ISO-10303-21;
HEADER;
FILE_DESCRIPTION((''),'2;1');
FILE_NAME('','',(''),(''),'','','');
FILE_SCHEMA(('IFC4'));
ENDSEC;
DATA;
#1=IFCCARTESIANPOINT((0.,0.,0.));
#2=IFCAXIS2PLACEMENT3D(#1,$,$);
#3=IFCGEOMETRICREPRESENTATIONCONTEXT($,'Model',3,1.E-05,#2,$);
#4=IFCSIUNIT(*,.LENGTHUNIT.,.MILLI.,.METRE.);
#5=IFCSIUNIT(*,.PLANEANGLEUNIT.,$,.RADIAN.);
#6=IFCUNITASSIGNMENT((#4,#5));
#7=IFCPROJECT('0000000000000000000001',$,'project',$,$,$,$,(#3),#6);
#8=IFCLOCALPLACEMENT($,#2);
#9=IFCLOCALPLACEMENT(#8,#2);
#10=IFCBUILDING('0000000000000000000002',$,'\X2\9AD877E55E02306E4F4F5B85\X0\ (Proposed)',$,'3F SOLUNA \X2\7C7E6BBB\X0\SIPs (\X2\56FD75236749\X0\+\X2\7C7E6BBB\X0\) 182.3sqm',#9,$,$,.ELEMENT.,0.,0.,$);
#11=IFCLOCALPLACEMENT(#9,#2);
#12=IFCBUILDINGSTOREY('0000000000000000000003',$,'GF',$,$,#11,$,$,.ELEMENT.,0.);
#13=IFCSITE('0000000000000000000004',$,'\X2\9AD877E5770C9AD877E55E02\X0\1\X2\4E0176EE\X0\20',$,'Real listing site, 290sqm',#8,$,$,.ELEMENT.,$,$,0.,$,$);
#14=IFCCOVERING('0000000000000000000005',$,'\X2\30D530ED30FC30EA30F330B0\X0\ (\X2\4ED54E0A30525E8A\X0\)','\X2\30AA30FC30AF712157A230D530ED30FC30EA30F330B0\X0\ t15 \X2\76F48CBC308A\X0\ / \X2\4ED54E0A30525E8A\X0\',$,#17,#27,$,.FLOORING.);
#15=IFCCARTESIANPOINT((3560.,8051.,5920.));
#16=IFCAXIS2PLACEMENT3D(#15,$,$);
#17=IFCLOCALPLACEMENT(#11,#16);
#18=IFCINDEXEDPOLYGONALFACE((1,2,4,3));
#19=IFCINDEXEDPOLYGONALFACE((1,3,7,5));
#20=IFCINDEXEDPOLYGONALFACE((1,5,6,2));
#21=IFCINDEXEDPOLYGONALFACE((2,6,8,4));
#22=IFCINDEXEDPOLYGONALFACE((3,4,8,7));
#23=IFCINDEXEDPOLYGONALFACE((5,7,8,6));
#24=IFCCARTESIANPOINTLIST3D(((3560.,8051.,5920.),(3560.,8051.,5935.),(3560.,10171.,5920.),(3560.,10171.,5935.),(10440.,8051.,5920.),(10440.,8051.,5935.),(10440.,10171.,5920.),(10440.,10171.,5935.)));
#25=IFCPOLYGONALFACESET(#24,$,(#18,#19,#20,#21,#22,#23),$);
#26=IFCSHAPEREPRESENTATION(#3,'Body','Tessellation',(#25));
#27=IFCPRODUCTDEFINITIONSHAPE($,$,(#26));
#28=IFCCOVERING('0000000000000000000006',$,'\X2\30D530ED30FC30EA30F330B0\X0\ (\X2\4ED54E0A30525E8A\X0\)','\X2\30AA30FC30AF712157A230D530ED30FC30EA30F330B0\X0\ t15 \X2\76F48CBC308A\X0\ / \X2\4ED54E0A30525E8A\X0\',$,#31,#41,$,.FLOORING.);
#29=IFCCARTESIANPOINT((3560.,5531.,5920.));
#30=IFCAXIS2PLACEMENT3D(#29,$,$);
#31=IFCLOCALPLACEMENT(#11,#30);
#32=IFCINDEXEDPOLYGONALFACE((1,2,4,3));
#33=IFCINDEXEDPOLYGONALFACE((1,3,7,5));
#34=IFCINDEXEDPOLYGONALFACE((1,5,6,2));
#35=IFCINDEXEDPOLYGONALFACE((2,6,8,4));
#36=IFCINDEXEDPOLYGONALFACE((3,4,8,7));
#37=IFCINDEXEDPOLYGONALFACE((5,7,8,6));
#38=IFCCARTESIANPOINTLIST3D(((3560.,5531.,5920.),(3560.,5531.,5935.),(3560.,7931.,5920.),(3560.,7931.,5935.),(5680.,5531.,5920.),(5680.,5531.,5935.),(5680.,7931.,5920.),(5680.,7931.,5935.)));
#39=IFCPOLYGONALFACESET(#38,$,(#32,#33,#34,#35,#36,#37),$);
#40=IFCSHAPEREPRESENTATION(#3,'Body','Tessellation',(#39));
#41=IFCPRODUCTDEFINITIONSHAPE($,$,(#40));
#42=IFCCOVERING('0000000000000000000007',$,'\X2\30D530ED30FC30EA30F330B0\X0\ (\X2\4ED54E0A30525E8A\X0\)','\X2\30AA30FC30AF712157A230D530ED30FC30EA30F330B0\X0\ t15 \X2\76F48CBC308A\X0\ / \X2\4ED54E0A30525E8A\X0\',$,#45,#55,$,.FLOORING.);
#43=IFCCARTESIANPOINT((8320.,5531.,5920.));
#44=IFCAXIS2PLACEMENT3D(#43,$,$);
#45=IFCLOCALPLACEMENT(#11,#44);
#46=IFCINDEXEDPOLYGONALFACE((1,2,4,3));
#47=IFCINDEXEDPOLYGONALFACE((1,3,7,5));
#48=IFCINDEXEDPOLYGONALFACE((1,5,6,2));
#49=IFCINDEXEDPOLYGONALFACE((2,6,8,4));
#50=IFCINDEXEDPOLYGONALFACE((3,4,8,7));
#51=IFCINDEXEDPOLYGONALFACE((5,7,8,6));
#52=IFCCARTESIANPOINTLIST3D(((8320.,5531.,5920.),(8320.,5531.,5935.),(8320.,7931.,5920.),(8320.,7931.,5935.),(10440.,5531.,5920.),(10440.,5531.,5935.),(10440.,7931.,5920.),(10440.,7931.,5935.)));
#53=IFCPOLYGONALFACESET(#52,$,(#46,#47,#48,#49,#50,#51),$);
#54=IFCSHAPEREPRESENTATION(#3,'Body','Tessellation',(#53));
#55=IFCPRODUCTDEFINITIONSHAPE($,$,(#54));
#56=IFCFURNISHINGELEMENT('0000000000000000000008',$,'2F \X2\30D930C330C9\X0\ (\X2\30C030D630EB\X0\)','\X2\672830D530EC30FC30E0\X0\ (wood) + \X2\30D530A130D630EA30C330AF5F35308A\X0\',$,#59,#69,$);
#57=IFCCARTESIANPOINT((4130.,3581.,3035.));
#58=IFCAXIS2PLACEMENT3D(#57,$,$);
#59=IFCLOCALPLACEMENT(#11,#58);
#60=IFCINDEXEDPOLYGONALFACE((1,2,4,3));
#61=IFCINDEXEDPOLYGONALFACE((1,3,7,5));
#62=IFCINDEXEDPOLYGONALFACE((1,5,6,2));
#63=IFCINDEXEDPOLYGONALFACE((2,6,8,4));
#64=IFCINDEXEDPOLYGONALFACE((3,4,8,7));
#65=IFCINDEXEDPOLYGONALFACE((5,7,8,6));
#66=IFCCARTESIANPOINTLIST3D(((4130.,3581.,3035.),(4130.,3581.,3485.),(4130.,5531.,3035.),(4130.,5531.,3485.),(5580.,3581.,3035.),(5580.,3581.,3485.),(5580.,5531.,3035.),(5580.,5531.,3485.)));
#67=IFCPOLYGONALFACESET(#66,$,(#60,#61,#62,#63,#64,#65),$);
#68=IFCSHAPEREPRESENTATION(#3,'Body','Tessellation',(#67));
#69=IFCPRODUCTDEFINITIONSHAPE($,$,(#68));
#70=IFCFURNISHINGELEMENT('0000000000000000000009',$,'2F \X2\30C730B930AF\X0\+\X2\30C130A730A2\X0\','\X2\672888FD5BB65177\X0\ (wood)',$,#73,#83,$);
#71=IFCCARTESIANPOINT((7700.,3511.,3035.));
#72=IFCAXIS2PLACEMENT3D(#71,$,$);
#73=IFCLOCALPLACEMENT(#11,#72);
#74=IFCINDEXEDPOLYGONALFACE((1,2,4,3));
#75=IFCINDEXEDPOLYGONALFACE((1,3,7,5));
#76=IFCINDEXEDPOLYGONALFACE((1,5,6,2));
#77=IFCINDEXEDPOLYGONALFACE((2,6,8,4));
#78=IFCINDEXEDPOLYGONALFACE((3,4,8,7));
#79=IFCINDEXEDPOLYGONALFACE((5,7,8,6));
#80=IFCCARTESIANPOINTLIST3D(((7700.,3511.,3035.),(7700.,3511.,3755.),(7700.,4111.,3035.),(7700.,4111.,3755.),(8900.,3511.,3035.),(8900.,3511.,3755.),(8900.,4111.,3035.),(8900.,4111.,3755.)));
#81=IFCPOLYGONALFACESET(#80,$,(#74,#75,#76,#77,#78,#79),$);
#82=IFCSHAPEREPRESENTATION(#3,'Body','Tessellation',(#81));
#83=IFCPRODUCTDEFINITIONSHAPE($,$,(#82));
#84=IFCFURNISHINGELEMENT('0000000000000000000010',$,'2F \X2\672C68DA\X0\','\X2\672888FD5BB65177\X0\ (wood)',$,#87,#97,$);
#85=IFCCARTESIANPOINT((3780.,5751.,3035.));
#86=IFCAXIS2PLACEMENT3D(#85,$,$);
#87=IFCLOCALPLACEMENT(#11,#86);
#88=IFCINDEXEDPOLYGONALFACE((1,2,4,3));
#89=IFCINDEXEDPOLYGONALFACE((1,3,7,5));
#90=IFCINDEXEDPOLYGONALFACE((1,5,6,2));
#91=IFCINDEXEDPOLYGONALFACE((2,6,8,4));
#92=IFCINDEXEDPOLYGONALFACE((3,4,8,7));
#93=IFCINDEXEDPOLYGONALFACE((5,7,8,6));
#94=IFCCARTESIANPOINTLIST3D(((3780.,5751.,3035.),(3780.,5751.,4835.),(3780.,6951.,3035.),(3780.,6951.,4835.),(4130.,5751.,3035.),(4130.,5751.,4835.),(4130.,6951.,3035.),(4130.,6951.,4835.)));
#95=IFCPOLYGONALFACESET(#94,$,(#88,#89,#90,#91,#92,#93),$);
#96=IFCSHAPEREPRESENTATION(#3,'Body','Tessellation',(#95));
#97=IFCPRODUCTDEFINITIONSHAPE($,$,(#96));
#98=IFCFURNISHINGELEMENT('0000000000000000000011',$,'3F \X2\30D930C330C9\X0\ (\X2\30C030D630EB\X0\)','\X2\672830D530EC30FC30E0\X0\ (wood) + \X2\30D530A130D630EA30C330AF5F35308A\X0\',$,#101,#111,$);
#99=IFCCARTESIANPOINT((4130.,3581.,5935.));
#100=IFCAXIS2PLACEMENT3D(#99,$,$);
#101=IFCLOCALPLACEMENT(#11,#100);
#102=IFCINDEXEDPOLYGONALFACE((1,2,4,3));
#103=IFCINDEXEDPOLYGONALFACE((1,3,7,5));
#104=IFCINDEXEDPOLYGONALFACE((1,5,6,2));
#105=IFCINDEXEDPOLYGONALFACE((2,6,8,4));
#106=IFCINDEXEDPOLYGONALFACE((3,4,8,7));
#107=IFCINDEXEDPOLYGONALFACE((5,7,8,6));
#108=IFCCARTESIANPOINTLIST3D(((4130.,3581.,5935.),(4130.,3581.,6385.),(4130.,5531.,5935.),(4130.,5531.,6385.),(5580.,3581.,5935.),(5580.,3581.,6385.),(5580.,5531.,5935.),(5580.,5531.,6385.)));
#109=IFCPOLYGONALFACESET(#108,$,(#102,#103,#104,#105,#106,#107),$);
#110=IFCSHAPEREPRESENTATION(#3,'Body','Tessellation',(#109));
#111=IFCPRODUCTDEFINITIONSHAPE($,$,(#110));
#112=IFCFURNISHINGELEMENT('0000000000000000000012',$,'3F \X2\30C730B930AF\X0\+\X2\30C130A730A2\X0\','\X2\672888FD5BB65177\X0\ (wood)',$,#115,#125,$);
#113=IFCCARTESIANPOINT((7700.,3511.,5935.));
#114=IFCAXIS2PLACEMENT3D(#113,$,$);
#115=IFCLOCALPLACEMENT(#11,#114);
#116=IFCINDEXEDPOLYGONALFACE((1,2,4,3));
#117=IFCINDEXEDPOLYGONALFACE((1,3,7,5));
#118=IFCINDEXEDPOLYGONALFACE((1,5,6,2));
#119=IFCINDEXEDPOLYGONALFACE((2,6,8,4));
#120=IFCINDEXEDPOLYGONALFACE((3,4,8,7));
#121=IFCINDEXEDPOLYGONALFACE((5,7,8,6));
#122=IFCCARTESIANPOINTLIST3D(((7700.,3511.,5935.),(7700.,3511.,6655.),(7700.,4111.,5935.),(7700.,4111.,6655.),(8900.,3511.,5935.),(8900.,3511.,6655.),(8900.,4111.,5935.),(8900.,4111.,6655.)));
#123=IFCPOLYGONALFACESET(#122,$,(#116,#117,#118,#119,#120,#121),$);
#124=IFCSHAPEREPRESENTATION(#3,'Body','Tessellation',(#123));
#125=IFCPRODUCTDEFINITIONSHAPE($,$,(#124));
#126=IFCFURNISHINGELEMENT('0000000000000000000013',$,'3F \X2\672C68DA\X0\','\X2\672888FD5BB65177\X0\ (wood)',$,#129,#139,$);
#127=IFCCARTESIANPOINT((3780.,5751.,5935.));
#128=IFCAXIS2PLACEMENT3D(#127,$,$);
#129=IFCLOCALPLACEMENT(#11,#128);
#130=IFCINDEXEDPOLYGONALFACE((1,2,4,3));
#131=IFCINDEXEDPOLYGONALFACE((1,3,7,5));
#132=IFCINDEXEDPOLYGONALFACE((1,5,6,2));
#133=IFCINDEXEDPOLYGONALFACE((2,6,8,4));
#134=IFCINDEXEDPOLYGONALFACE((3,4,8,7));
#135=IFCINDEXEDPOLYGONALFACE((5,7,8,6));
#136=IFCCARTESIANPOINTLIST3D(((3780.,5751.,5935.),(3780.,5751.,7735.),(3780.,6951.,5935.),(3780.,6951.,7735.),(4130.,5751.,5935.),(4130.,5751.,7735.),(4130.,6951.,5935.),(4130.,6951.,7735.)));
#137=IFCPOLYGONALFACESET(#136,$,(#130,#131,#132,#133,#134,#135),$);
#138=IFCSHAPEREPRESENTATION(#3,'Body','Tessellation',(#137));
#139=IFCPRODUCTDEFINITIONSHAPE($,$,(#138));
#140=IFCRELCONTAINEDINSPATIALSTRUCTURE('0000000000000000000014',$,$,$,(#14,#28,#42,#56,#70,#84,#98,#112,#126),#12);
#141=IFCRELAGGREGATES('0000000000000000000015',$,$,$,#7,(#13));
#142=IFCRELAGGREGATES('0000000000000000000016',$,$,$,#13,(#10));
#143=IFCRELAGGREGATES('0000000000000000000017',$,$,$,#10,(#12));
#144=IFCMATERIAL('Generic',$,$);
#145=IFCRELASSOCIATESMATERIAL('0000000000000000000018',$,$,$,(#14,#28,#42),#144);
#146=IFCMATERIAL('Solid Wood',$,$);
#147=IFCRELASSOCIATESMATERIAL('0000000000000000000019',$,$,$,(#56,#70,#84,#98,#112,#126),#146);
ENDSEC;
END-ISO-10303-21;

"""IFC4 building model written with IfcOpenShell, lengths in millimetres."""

from ifc_helpers import new_model, si_unit, frame, frame_2d, origin, place, context, project, spatial, rectangle, extrude, material, element, save


model = new_model("IFC4")

# Units and contexts
model_context = context("Model", 3, precision=1e-05, world=origin())
ifc_project = project(units=[si_unit("LENGTHUNIT", "METRE", prefix="MILLI"), si_unit("PLANEANGLEUNIT", "RADIAN")], contexts=[model_context])

# Site, building, storey
site_placement = place(None, origin())
site = spatial("IfcSite", under=ifc_project, at=site_placement, Name="高知県高知市1丁目20", ObjectType="Real listing site, 290sqm", CompositionType="ELEMENT", RefElevation=0.0)
building_placement = place(site_placement, origin())
building = spatial("IfcBuilding", under=site, at=building_placement, Name="高知市の住宅 (Proposed)", ObjectType="3F SOLUNA 籾殻SIPs (国産杉+籾殻) 182.3sqm", CompositionType="ELEMENT", ElevationOfRefHeight=0.0, ElevationOfTerrain=0.0)
storey_placement = place(building_placement, origin())
storey = spatial("IfcBuildingStorey", under=building, at=storey_placement, Name="GF", CompositionType="ELEMENT", Elevation=0.0)

# Shared definitions
ifc_material_1 = material(Name="Solid Wood")

# Shared definitions
ifc_material_2 = material(Name="Generic")

# Coverings
covering_1_placement = place(storey_placement, frame((3560.0, 8051.0, 5920.0)))
element("IfcCovering", 1, at=covering_1_placement, inside=storey, material=ifc_material_2, Name="フローリング (仕上げ床)", Description="オーク無垢フローリング t15 直貼り / 仕上げ床", PredefinedType="FLOORING", context=model_context, shape_type="SweptSolid", body=[
    extrude(rectangle(XDim=6880.0, YDim=2120.0, at=frame_2d((3440.0, 1060.0))), frame((3560.0, 8051.0, 5920.0)), (0.0, 0.0, 1.0), 15.0),
])
covering_2_placement = place(storey_placement, frame((3560.0, 5531.0, 5920.0)))
element("IfcCovering", 2, at=covering_2_placement, inside=storey, material=ifc_material_2, Name="フローリング (仕上げ床)", Description="オーク無垢フローリング t15 直貼り / 仕上げ床", PredefinedType="FLOORING", context=model_context, shape_type="SweptSolid", body=[
    extrude(rectangle(XDim=2120.0, YDim=2400.0, at=frame_2d((1060.0, 1200.0))), frame((3560.0, 5531.0, 5920.0)), (0.0, 0.0, 1.0), 15.0),
])
covering_3_placement = place(storey_placement, frame((8320.0, 5531.0, 5920.0)))
element("IfcCovering", 3, at=covering_3_placement, inside=storey, material=ifc_material_2, Name="フローリング (仕上げ床)", Description="オーク無垢フローリング t15 直貼り / 仕上げ床", PredefinedType="FLOORING", context=model_context, shape_type="SweptSolid", body=[
    extrude(rectangle(XDim=2120.0, YDim=2400.0, at=frame_2d((1060.0, 1200.0))), frame((8320.0, 5531.0, 5920.0)), (0.0, 0.0, 1.0), 15.0),
])

# Furnishing elements
furnishing_1_placement = place(storey_placement, frame((4130.0, 3581.0, 3035.0)))
element("IfcFurnishingElement", 4, at=furnishing_1_placement, inside=storey, material=ifc_material_1, Name="2F ベッド (ダブル)", Description="木フレーム (wood) + ファブリック張り", context=model_context, shape_type="SweptSolid", body=[
    extrude(rectangle(XDim=1450.0, YDim=1950.0, at=frame_2d((725.0, 975.0))), frame((4130.0, 3581.0, 3035.0)), (0.0, 0.0, 1.0), 450.0),
])
furnishing_2_placement = place(storey_placement, frame((7700.0, 3511.0, 3035.0)))
element("IfcFurnishingElement", 5, at=furnishing_2_placement, inside=storey, material=ifc_material_1, Name="2F デスク+チェア", Description="木製家具 (wood)", context=model_context, shape_type="SweptSolid", body=[
    extrude(rectangle(XDim=1200.0, YDim=600.0, at=frame_2d((600.0, 300.0))), frame((7700.0, 3511.0, 3035.0)), (0.0, 0.0, 1.0), 720.0),
])
furnishing_3_placement = place(storey_placement, frame((3780.0, 5751.0, 3035.0)))
element("IfcFurnishingElement", 6, at=furnishing_3_placement, inside=storey, material=ifc_material_1, Name="2F 本棚", Description="木製家具 (wood)", context=model_context, shape_type="SweptSolid", body=[
    extrude(rectangle(XDim=350.0, YDim=1200.0, at=frame_2d((175.0, 600.0))), frame((3780.0, 5751.0, 3035.0)), (0.0, 0.0, 1.0), 1800.0),
])
furnishing_4_placement = place(storey_placement, frame((4130.0, 3581.0, 5935.0)))
element("IfcFurnishingElement", 7, at=furnishing_4_placement, inside=storey, material=ifc_material_1, Name="3F ベッド (ダブル)", Description="木フレーム (wood) + ファブリック張り", context=model_context, shape_type="SweptSolid", body=[
    extrude(rectangle(XDim=1450.0, YDim=1950.0, at=frame_2d((725.0, 975.0))), frame((4130.0, 3581.0, 5935.0)), (0.0, 0.0, 1.0), 450.0),
])
furnishing_5_placement = place(storey_placement, frame((7700.0, 3511.0, 5935.0)))
element("IfcFurnishingElement", 8, at=furnishing_5_placement, inside=storey, material=ifc_material_1, Name="3F デスク+チェア", Description="木製家具 (wood)", context=model_context, shape_type="SweptSolid", body=[
    extrude(rectangle(XDim=1200.0, YDim=600.0, at=frame_2d((600.0, 300.0))), frame((7700.0, 3511.0, 5935.0)), (0.0, 0.0, 1.0), 720.0),
])
furnishing_6_placement = place(storey_placement, frame((3780.0, 5751.0, 5935.0)))
element("IfcFurnishingElement", 9, at=furnishing_6_placement, inside=storey, material=ifc_material_1, Name="3F 本棚", Description="木製家具 (wood)", context=model_context, shape_type="SweptSolid", body=[
    extrude(rectangle(XDim=350.0, YDim=1200.0, at=frame_2d((175.0, 600.0))), frame((3780.0, 5751.0, 5935.0)), (0.0, 0.0, 1.0), 1800.0),
])

save(model, "model.ifc")
